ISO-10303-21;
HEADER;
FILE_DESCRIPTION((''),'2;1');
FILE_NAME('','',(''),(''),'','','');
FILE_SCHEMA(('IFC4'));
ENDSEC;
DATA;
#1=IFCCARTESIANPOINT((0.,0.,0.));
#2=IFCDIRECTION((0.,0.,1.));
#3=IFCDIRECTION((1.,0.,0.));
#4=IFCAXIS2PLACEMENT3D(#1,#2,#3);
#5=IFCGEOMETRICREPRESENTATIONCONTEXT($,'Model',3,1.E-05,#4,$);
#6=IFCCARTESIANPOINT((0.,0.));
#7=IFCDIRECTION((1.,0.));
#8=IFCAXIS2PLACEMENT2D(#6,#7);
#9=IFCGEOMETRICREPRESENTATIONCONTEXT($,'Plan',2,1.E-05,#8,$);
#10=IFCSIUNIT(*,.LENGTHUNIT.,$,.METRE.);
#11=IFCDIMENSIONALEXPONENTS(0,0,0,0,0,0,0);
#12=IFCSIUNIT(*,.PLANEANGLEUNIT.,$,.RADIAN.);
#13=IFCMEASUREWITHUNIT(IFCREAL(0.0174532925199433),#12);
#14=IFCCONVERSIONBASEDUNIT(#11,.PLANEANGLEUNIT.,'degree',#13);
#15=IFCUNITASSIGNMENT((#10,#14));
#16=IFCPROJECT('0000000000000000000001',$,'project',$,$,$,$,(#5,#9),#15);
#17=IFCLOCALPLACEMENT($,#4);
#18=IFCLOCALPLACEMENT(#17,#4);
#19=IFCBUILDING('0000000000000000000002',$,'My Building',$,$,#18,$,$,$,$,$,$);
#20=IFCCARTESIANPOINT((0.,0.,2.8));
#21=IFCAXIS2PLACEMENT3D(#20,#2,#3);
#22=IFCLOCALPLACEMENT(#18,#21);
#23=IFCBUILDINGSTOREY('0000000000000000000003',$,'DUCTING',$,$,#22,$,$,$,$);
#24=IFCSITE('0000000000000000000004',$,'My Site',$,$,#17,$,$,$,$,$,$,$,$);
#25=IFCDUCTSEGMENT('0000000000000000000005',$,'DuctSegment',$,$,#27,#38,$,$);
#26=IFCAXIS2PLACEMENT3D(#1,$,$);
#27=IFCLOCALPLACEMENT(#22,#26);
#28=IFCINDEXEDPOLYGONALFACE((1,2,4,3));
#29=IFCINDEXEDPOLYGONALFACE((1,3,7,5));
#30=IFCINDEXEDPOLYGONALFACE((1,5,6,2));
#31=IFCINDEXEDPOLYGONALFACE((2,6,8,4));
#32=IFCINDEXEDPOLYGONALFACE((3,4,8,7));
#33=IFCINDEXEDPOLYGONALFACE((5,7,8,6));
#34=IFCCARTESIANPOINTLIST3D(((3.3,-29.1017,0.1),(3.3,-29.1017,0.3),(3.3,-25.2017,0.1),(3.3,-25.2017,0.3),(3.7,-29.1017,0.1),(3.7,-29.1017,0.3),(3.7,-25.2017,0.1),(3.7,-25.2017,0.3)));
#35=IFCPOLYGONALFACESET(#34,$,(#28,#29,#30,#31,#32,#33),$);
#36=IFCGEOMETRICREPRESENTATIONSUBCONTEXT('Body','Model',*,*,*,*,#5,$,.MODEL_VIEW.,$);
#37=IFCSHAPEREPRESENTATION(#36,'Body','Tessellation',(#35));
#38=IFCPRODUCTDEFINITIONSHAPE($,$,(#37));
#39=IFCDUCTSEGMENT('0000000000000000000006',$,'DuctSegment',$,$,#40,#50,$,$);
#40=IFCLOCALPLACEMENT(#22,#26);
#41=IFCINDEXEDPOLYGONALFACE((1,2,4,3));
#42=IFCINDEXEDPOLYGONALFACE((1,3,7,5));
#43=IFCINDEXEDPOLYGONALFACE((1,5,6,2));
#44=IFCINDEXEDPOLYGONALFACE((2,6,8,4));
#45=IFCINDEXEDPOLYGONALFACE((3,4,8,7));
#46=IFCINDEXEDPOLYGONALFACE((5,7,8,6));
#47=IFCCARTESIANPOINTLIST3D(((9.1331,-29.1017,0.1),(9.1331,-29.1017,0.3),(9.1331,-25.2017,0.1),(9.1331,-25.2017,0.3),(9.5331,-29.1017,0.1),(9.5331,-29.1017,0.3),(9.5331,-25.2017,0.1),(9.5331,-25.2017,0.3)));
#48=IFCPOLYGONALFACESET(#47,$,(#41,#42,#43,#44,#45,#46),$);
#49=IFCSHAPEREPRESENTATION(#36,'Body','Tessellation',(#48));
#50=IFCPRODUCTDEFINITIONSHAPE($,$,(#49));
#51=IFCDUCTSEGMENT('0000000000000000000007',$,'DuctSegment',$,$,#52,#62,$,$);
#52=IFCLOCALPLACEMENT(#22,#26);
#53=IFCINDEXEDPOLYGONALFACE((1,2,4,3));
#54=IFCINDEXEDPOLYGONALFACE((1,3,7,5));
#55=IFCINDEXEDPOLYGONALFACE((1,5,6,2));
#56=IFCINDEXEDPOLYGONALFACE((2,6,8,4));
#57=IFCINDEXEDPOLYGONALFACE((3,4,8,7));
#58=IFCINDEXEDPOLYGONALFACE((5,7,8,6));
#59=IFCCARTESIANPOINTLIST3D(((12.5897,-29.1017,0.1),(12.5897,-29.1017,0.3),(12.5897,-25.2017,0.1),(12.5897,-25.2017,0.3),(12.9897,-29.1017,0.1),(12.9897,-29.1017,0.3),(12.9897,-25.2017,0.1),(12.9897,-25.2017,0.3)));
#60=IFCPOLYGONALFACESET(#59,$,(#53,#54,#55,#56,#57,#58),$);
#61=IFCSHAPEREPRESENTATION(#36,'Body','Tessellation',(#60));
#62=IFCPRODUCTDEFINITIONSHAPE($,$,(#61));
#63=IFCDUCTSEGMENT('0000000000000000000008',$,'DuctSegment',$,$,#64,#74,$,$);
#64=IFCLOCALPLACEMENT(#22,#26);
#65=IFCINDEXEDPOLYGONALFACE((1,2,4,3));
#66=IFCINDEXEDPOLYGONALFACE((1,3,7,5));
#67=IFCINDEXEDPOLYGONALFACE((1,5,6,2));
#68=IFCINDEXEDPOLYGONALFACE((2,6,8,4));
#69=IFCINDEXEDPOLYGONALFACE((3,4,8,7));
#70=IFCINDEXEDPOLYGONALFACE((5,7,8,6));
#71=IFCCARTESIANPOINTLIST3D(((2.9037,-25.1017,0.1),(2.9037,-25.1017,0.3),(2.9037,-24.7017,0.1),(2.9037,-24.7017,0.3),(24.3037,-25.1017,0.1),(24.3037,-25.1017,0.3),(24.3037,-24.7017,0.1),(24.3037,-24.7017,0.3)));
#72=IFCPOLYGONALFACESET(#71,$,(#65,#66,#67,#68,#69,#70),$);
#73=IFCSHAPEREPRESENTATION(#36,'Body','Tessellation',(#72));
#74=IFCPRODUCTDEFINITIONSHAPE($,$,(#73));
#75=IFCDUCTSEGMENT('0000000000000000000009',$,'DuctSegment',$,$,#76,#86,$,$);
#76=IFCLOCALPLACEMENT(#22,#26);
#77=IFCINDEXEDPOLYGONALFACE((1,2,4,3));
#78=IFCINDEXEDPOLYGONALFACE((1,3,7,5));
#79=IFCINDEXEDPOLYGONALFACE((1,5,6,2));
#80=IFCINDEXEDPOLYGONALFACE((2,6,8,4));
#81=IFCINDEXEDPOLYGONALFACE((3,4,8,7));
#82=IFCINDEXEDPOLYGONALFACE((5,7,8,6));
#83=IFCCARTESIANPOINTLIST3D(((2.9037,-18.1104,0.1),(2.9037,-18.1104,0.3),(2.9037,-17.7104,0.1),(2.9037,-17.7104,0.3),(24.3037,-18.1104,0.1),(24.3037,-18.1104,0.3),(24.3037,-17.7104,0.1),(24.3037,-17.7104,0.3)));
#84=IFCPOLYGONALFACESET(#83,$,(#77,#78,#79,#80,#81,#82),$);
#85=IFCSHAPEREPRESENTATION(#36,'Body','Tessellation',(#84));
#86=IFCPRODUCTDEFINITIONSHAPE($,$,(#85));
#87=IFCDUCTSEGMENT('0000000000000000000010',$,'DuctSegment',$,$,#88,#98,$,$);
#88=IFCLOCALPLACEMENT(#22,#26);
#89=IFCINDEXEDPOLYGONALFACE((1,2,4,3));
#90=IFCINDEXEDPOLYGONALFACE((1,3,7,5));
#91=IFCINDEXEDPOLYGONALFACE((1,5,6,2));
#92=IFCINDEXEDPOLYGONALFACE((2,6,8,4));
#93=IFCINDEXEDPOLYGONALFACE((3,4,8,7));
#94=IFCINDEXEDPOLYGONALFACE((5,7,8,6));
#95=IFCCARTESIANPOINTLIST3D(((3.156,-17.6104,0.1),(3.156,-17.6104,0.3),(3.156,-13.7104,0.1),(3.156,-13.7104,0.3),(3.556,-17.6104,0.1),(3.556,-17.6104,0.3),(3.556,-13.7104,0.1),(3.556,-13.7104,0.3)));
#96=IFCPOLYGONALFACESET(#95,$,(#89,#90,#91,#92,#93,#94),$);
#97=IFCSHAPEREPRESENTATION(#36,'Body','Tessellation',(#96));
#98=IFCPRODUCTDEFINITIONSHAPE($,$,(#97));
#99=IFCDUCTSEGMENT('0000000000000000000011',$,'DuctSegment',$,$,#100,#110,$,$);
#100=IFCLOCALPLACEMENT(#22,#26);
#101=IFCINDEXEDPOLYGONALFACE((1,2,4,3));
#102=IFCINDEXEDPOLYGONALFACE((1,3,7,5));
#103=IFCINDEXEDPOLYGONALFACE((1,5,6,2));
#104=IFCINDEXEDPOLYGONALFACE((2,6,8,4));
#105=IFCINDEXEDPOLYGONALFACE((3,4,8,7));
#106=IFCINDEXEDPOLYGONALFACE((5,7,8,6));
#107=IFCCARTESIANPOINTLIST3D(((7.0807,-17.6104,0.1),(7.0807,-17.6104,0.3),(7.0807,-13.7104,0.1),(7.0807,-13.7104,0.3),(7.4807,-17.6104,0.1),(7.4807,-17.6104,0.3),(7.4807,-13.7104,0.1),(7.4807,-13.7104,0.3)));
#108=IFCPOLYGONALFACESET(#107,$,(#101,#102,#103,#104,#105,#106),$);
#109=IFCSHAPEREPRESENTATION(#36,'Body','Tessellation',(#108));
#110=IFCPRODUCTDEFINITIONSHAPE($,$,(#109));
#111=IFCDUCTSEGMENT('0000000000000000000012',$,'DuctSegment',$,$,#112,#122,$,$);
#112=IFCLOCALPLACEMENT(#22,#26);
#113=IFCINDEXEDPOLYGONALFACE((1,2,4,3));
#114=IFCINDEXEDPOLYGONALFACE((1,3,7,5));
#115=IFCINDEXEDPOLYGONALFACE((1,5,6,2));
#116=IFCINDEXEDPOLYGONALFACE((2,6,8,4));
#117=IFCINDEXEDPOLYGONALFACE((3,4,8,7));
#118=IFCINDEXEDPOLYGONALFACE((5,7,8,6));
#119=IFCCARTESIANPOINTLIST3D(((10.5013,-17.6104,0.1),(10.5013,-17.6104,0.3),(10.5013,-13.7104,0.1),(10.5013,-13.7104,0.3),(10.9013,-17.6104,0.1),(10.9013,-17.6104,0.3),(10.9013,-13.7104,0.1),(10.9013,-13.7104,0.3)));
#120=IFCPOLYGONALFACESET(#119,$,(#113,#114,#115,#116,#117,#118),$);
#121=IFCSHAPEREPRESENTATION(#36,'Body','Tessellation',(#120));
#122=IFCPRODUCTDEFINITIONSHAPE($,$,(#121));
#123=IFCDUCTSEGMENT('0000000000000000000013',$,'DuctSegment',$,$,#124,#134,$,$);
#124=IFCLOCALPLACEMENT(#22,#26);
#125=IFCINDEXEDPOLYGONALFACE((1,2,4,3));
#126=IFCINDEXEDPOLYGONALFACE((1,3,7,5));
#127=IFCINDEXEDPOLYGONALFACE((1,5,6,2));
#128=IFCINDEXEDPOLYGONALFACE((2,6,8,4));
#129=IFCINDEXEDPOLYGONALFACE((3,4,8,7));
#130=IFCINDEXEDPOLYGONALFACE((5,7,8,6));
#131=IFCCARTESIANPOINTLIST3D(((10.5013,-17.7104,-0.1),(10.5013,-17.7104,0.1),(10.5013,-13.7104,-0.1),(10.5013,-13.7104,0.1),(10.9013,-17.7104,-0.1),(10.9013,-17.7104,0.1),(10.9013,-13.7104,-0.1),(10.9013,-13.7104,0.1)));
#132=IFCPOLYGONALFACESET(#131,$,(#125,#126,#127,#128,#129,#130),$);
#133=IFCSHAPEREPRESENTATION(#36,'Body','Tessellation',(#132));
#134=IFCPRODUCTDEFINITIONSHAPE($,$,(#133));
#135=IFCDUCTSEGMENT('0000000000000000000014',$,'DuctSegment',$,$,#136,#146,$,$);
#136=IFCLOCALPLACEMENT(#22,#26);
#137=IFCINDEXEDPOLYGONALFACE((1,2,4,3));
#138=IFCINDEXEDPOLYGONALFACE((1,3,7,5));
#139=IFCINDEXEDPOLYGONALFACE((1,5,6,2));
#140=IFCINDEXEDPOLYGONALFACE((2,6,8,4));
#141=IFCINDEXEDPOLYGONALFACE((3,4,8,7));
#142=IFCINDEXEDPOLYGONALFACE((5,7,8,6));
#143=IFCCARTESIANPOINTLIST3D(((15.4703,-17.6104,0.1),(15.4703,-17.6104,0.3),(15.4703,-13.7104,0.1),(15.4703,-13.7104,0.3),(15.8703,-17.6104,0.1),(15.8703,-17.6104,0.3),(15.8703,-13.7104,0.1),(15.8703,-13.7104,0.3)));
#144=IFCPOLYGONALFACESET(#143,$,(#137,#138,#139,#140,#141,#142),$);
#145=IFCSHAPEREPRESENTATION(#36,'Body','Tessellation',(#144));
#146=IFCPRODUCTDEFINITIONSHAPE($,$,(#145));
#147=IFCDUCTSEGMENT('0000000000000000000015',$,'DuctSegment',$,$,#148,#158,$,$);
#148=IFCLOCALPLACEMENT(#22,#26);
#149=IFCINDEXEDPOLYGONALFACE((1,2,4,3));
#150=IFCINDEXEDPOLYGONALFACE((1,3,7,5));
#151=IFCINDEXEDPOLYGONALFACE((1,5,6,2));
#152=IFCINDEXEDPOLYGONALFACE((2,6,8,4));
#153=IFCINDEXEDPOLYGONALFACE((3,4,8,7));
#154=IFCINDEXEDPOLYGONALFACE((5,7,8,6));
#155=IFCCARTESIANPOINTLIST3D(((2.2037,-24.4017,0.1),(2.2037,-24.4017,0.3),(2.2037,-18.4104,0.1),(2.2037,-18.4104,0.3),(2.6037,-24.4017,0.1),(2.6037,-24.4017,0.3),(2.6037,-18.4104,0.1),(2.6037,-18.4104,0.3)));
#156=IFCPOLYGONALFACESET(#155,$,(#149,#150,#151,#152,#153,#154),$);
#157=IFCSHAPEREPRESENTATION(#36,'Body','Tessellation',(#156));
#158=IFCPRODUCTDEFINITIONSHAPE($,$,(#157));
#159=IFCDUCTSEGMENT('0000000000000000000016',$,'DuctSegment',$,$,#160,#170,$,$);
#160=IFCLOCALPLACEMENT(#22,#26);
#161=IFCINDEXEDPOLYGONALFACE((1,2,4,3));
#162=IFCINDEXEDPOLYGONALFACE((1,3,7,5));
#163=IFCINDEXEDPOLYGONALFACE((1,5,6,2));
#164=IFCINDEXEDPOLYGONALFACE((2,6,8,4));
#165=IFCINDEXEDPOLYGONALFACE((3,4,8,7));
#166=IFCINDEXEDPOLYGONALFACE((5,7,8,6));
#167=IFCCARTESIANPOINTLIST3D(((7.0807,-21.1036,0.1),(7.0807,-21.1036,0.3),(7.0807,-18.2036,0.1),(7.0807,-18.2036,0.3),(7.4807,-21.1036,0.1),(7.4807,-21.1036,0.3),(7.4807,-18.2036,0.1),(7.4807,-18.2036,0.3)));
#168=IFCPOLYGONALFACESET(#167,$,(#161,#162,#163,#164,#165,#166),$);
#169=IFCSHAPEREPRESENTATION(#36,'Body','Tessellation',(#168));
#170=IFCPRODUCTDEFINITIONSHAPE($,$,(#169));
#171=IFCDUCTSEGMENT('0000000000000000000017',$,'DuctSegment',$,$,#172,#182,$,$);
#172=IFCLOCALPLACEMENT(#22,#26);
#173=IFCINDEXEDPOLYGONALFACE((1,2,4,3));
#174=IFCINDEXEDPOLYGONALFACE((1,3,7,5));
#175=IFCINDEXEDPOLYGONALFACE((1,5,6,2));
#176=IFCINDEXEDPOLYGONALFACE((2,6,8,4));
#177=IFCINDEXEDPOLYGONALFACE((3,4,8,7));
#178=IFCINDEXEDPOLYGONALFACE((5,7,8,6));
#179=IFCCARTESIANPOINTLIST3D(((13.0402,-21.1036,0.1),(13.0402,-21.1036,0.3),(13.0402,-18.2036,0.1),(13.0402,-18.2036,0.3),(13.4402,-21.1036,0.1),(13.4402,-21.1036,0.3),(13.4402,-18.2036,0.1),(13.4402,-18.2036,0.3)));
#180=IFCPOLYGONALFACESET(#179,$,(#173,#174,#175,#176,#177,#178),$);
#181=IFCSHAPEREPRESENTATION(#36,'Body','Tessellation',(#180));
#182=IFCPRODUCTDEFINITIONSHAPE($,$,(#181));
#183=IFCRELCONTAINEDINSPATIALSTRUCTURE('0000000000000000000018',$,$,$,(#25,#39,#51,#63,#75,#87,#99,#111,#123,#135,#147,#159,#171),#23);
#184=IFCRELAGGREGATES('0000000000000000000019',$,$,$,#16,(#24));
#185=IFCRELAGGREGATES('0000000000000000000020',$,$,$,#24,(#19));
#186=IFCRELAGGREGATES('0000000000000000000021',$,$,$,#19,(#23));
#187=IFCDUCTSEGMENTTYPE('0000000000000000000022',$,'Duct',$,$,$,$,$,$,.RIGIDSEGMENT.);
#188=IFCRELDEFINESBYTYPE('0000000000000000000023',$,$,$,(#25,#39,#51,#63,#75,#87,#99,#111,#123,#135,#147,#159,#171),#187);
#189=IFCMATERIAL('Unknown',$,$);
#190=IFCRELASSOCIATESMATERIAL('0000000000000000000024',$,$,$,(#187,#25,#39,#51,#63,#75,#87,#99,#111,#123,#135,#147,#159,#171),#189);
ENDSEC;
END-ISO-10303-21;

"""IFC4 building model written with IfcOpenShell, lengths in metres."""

from ifc_helpers import new_model, entity, si_unit, converted_unit, frame, origin_with_axes, origin_2d_with_axis, place, context, subcontext, project, spatial, rectangle, extrude, material, material_profile, profile_set, profile_usage, type_object, element, save


model = new_model("IFC4")

# Units and contexts
model_context = context("Model", 3, precision=1e-05, world=origin_with_axes())
plan_context = context("Plan", 2, precision=1e-05, world=origin_2d_with_axis())
body_context = subcontext(model_context, "Body", "Model", "MODEL_VIEW")
ifc_project = project(units=[si_unit("LENGTHUNIT", "METRE"), converted_unit("PLANEANGLEUNIT", "degree", entity("IfcReal", 0.0174532925199433), si_unit("PLANEANGLEUNIT", "RADIAN"), dimensions=[0, 0, 0, 0, 0, 0, 0])], contexts=[model_context, plan_context])

# Site, building, storey
site_placement = place(None, origin_with_axes())
site = spatial("IfcSite", under=ifc_project, at=site_placement, Name="My Site")
building_placement = place(site_placement, origin_with_axes())
building = spatial("IfcBuilding", under=site, at=building_placement, Name="My Building")
storey_placement = place(building_placement, frame((0.0, 0.0, 2.8), z_axis=(0.0, 0.0, 1.0), x_axis=(1.0, 0.0, 0.0)))
storey = spatial("IfcBuildingStorey", under=building, at=storey_placement, Name="DUCTING")

# Duct segments
ifc_material = material(Name="Unknown")
ifc_material_profile_1 = material_profile(ifc_material, rectangle(XDim=0.4, YDim=0.2))
ifc_profile_set_1 = profile_set([ifc_material_profile_1])
ifc_profile_usage_1 = profile_usage(ifc_profile_set_1, cardinal=5)
duct_segment_type = type_object("IfcDuctSegmentType", Name="Duct", PredefinedType="RIGIDSEGMENT", material=ifc_profile_set_1)
duct_segment_1_placement = place(storey_placement, frame((3.5, -25.2017, 0.2), z_axis=(0.0, -1.0, 0.0), x_axis=(1.0, 0.0, 0.0)))
element("IfcDuctSegment", 1, at=duct_segment_1_placement, inside=storey, type_object=duct_segment_type, material=ifc_profile_usage_1, Name="DuctSegment", context=body_context, shape_type="SweptSolid", body=[
    extrude(rectangle(XDim=0.4, YDim=0.2), origin_with_axes(), (0.0, 0.0, 1.0), 3.9),
])
ifc_profile_usage_2 = profile_usage(ifc_profile_set_1, cardinal=5)
duct_segment_2_placement = place(storey_placement, frame((9.3331, -25.2017, 0.2), z_axis=(0.0, -1.0, 0.0), x_axis=(1.0, 0.0, 0.0)))
element("IfcDuctSegment", 2, at=duct_segment_2_placement, inside=storey, type_object=duct_segment_type, material=ifc_profile_usage_2, Name="DuctSegment", context=body_context, shape_type="SweptSolid", body=[
    extrude(rectangle(XDim=0.4, YDim=0.2), origin_with_axes(), (0.0, 0.0, 1.0), 3.9),
])
ifc_profile_usage_3 = profile_usage(ifc_profile_set_1, cardinal=5)
duct_segment_3_placement = place(storey_placement, frame((12.7897, -25.2017, 0.2), z_axis=(0.0, -1.0, 0.0), x_axis=(1.0, 0.0, 0.0)))
element("IfcDuctSegment", 3, at=duct_segment_3_placement, inside=storey, type_object=duct_segment_type, material=ifc_profile_usage_3, Name="DuctSegment", context=body_context, shape_type="SweptSolid", body=[
    extrude(rectangle(XDim=0.4, YDim=0.2), origin_with_axes(), (0.0, 0.0, 1.0), 3.9),
])
ifc_profile_usage_4 = profile_usage(ifc_profile_set_1, cardinal=5)
duct_segment_4_placement = place(storey_placement, frame((2.9037, -24.9017, 0.2), z_axis=(1.0, 0.0, 0.0), x_axis=(0.0, 1.0, 0.0)))
element("IfcDuctSegment", 4, at=duct_segment_4_placement, inside=storey, type_object=duct_segment_type, material=ifc_profile_usage_4, Name="DuctSegment", context=body_context, shape_type="SweptSolid", body=[
    extrude(rectangle(XDim=0.4, YDim=0.2), origin_with_axes(), (0.0, 0.0, 1.0), 21.4),
])
ifc_profile_usage_5 = profile_usage(ifc_profile_set_1, cardinal=5)
duct_segment_5_placement = place(storey_placement, frame((2.9037, -17.9104, 0.2), z_axis=(1.0, 0.0, 0.0), x_axis=(0.0, 1.0, 0.0)))
element("IfcDuctSegment", 5, at=duct_segment_5_placement, inside=storey, type_object=duct_segment_type, material=ifc_profile_usage_5, Name="DuctSegment", context=body_context, shape_type="SweptSolid", body=[
    extrude(rectangle(XDim=0.4, YDim=0.2), origin_with_axes(), (0.0, 0.0, 1.0), 21.4),
])
ifc_profile_usage_6 = profile_usage(ifc_profile_set_1, cardinal=5)
duct_segment_6_placement = place(storey_placement, frame((3.356, -17.6104, 0.2), z_axis=(0.0, 1.0, 0.0), x_axis=(1.0, 0.0, 0.0)))
element("IfcDuctSegment", 6, at=duct_segment_6_placement, inside=storey, type_object=duct_segment_type, material=ifc_profile_usage_6, Name="DuctSegment", context=body_context, shape_type="SweptSolid", body=[
    extrude(rectangle(XDim=0.4, YDim=0.2), origin_with_axes(), (0.0, 0.0, 1.0), 3.9),
])
ifc_profile_usage_7 = profile_usage(ifc_profile_set_1, cardinal=5)
duct_segment_7_placement = place(storey_placement, frame((7.2807, -17.6104, 0.2), z_axis=(0.0, 1.0, 0.0), x_axis=(1.0, 0.0, 0.0)))
element("IfcDuctSegment", 7, at=duct_segment_7_placement, inside=storey, type_object=duct_segment_type, material=ifc_profile_usage_7, Name="DuctSegment", context=body_context, shape_type="SweptSolid", body=[
    extrude(rectangle(XDim=0.4, YDim=0.2), origin_with_axes(), (0.0, 0.0, 1.0), 3.9),
])
ifc_profile_usage_8 = profile_usage(ifc_profile_set_1, cardinal=5)
duct_segment_8_placement = place(storey_placement, frame((10.7013, -17.6104, 0.2), z_axis=(0.0, 1.0, 0.0), x_axis=(1.0, 0.0, 0.0)))
element("IfcDuctSegment", 8, at=duct_segment_8_placement, inside=storey, type_object=duct_segment_type, material=ifc_profile_usage_8, Name="DuctSegment", context=body_context, shape_type="SweptSolid", body=[
    extrude(rectangle(XDim=0.4, YDim=0.2), origin_with_axes(), (0.0, 0.0, 1.0), 3.9),
])
ifc_profile_usage_9 = profile_usage(ifc_profile_set_1, cardinal=5)
duct_segment_9_placement = place(storey_placement, frame((10.7013, -13.7104, 0.0), z_axis=(0.0, -1.0, 0.0), x_axis=(1.0, 0.0, 0.0)))
element("IfcDuctSegment", 9, at=duct_segment_9_placement, inside=storey, type_object=duct_segment_type, material=ifc_profile_usage_9, Name="DuctSegment", context=body_context, shape_type="SweptSolid", body=[
    extrude(rectangle(XDim=0.4, YDim=0.2), origin_with_axes(), (0.0, 0.0, 1.0), 4.0),
])
ifc_profile_usage_10 = profile_usage(ifc_profile_set_1, cardinal=5)
duct_segment_10_placement = place(storey_placement, frame((15.6703, -17.6104, 0.2), z_axis=(0.0, 1.0, 0.0), x_axis=(1.0, 0.0, 0.0)))
element("IfcDuctSegment", 10, at=duct_segment_10_placement, inside=storey, type_object=duct_segment_type, material=ifc_profile_usage_10, Name="DuctSegment", context=body_context, shape_type="SweptSolid", body=[
    extrude(rectangle(XDim=0.4, YDim=0.2), origin_with_axes(), (0.0, 0.0, 1.0), 3.9),
])
ifc_profile_usage_11 = profile_usage(ifc_profile_set_1, cardinal=5)
duct_segment_11_placement = place(storey_placement, frame((2.4037, -18.4104, 0.2), z_axis=(0.0, -1.0, 0.0), x_axis=(1.0, 0.0, 0.0)))
element("IfcDuctSegment", 11, at=duct_segment_11_placement, inside=storey, type_object=duct_segment_type, material=ifc_profile_usage_11, Name="DuctSegment", context=body_context, shape_type="SweptSolid", body=[
    extrude(rectangle(XDim=0.4, YDim=0.2), origin_with_axes(), (0.0, 0.0, 1.0), 5.9913),
])
ifc_profile_usage_12 = profile_usage(ifc_profile_set_1, cardinal=5)
duct_segment_12_placement = place(storey_placement, frame((7.2807, -18.2036, 0.2), z_axis=(0.0, -1.0, 0.0), x_axis=(1.0, 0.0, 0.0)))
element("IfcDuctSegment", 12, at=duct_segment_12_placement, inside=storey, type_object=duct_segment_type, material=ifc_profile_usage_12, Name="DuctSegment", context=body_context, shape_type="SweptSolid", body=[
    extrude(rectangle(XDim=0.4, YDim=0.2), origin_with_axes(), (0.0, 0.0, 1.0), 2.9),
])
ifc_profile_usage_13 = profile_usage(ifc_profile_set_1, cardinal=5)
duct_segment_13_placement = place(storey_placement, frame((13.2402, -18.2036, 0.2), z_axis=(0.0, -1.0, 0.0), x_axis=(1.0, 0.0, 0.0)))
element("IfcDuctSegment", 13, at=duct_segment_13_placement, inside=storey, type_object=duct_segment_type, material=ifc_profile_usage_13, Name="DuctSegment", context=body_context, shape_type="SweptSolid", body=[
    extrude(rectangle(XDim=0.4, YDim=0.2), origin_with_axes(), (0.0, 0.0, 1.0), 2.9),
])

save(model, "model.ifc")
